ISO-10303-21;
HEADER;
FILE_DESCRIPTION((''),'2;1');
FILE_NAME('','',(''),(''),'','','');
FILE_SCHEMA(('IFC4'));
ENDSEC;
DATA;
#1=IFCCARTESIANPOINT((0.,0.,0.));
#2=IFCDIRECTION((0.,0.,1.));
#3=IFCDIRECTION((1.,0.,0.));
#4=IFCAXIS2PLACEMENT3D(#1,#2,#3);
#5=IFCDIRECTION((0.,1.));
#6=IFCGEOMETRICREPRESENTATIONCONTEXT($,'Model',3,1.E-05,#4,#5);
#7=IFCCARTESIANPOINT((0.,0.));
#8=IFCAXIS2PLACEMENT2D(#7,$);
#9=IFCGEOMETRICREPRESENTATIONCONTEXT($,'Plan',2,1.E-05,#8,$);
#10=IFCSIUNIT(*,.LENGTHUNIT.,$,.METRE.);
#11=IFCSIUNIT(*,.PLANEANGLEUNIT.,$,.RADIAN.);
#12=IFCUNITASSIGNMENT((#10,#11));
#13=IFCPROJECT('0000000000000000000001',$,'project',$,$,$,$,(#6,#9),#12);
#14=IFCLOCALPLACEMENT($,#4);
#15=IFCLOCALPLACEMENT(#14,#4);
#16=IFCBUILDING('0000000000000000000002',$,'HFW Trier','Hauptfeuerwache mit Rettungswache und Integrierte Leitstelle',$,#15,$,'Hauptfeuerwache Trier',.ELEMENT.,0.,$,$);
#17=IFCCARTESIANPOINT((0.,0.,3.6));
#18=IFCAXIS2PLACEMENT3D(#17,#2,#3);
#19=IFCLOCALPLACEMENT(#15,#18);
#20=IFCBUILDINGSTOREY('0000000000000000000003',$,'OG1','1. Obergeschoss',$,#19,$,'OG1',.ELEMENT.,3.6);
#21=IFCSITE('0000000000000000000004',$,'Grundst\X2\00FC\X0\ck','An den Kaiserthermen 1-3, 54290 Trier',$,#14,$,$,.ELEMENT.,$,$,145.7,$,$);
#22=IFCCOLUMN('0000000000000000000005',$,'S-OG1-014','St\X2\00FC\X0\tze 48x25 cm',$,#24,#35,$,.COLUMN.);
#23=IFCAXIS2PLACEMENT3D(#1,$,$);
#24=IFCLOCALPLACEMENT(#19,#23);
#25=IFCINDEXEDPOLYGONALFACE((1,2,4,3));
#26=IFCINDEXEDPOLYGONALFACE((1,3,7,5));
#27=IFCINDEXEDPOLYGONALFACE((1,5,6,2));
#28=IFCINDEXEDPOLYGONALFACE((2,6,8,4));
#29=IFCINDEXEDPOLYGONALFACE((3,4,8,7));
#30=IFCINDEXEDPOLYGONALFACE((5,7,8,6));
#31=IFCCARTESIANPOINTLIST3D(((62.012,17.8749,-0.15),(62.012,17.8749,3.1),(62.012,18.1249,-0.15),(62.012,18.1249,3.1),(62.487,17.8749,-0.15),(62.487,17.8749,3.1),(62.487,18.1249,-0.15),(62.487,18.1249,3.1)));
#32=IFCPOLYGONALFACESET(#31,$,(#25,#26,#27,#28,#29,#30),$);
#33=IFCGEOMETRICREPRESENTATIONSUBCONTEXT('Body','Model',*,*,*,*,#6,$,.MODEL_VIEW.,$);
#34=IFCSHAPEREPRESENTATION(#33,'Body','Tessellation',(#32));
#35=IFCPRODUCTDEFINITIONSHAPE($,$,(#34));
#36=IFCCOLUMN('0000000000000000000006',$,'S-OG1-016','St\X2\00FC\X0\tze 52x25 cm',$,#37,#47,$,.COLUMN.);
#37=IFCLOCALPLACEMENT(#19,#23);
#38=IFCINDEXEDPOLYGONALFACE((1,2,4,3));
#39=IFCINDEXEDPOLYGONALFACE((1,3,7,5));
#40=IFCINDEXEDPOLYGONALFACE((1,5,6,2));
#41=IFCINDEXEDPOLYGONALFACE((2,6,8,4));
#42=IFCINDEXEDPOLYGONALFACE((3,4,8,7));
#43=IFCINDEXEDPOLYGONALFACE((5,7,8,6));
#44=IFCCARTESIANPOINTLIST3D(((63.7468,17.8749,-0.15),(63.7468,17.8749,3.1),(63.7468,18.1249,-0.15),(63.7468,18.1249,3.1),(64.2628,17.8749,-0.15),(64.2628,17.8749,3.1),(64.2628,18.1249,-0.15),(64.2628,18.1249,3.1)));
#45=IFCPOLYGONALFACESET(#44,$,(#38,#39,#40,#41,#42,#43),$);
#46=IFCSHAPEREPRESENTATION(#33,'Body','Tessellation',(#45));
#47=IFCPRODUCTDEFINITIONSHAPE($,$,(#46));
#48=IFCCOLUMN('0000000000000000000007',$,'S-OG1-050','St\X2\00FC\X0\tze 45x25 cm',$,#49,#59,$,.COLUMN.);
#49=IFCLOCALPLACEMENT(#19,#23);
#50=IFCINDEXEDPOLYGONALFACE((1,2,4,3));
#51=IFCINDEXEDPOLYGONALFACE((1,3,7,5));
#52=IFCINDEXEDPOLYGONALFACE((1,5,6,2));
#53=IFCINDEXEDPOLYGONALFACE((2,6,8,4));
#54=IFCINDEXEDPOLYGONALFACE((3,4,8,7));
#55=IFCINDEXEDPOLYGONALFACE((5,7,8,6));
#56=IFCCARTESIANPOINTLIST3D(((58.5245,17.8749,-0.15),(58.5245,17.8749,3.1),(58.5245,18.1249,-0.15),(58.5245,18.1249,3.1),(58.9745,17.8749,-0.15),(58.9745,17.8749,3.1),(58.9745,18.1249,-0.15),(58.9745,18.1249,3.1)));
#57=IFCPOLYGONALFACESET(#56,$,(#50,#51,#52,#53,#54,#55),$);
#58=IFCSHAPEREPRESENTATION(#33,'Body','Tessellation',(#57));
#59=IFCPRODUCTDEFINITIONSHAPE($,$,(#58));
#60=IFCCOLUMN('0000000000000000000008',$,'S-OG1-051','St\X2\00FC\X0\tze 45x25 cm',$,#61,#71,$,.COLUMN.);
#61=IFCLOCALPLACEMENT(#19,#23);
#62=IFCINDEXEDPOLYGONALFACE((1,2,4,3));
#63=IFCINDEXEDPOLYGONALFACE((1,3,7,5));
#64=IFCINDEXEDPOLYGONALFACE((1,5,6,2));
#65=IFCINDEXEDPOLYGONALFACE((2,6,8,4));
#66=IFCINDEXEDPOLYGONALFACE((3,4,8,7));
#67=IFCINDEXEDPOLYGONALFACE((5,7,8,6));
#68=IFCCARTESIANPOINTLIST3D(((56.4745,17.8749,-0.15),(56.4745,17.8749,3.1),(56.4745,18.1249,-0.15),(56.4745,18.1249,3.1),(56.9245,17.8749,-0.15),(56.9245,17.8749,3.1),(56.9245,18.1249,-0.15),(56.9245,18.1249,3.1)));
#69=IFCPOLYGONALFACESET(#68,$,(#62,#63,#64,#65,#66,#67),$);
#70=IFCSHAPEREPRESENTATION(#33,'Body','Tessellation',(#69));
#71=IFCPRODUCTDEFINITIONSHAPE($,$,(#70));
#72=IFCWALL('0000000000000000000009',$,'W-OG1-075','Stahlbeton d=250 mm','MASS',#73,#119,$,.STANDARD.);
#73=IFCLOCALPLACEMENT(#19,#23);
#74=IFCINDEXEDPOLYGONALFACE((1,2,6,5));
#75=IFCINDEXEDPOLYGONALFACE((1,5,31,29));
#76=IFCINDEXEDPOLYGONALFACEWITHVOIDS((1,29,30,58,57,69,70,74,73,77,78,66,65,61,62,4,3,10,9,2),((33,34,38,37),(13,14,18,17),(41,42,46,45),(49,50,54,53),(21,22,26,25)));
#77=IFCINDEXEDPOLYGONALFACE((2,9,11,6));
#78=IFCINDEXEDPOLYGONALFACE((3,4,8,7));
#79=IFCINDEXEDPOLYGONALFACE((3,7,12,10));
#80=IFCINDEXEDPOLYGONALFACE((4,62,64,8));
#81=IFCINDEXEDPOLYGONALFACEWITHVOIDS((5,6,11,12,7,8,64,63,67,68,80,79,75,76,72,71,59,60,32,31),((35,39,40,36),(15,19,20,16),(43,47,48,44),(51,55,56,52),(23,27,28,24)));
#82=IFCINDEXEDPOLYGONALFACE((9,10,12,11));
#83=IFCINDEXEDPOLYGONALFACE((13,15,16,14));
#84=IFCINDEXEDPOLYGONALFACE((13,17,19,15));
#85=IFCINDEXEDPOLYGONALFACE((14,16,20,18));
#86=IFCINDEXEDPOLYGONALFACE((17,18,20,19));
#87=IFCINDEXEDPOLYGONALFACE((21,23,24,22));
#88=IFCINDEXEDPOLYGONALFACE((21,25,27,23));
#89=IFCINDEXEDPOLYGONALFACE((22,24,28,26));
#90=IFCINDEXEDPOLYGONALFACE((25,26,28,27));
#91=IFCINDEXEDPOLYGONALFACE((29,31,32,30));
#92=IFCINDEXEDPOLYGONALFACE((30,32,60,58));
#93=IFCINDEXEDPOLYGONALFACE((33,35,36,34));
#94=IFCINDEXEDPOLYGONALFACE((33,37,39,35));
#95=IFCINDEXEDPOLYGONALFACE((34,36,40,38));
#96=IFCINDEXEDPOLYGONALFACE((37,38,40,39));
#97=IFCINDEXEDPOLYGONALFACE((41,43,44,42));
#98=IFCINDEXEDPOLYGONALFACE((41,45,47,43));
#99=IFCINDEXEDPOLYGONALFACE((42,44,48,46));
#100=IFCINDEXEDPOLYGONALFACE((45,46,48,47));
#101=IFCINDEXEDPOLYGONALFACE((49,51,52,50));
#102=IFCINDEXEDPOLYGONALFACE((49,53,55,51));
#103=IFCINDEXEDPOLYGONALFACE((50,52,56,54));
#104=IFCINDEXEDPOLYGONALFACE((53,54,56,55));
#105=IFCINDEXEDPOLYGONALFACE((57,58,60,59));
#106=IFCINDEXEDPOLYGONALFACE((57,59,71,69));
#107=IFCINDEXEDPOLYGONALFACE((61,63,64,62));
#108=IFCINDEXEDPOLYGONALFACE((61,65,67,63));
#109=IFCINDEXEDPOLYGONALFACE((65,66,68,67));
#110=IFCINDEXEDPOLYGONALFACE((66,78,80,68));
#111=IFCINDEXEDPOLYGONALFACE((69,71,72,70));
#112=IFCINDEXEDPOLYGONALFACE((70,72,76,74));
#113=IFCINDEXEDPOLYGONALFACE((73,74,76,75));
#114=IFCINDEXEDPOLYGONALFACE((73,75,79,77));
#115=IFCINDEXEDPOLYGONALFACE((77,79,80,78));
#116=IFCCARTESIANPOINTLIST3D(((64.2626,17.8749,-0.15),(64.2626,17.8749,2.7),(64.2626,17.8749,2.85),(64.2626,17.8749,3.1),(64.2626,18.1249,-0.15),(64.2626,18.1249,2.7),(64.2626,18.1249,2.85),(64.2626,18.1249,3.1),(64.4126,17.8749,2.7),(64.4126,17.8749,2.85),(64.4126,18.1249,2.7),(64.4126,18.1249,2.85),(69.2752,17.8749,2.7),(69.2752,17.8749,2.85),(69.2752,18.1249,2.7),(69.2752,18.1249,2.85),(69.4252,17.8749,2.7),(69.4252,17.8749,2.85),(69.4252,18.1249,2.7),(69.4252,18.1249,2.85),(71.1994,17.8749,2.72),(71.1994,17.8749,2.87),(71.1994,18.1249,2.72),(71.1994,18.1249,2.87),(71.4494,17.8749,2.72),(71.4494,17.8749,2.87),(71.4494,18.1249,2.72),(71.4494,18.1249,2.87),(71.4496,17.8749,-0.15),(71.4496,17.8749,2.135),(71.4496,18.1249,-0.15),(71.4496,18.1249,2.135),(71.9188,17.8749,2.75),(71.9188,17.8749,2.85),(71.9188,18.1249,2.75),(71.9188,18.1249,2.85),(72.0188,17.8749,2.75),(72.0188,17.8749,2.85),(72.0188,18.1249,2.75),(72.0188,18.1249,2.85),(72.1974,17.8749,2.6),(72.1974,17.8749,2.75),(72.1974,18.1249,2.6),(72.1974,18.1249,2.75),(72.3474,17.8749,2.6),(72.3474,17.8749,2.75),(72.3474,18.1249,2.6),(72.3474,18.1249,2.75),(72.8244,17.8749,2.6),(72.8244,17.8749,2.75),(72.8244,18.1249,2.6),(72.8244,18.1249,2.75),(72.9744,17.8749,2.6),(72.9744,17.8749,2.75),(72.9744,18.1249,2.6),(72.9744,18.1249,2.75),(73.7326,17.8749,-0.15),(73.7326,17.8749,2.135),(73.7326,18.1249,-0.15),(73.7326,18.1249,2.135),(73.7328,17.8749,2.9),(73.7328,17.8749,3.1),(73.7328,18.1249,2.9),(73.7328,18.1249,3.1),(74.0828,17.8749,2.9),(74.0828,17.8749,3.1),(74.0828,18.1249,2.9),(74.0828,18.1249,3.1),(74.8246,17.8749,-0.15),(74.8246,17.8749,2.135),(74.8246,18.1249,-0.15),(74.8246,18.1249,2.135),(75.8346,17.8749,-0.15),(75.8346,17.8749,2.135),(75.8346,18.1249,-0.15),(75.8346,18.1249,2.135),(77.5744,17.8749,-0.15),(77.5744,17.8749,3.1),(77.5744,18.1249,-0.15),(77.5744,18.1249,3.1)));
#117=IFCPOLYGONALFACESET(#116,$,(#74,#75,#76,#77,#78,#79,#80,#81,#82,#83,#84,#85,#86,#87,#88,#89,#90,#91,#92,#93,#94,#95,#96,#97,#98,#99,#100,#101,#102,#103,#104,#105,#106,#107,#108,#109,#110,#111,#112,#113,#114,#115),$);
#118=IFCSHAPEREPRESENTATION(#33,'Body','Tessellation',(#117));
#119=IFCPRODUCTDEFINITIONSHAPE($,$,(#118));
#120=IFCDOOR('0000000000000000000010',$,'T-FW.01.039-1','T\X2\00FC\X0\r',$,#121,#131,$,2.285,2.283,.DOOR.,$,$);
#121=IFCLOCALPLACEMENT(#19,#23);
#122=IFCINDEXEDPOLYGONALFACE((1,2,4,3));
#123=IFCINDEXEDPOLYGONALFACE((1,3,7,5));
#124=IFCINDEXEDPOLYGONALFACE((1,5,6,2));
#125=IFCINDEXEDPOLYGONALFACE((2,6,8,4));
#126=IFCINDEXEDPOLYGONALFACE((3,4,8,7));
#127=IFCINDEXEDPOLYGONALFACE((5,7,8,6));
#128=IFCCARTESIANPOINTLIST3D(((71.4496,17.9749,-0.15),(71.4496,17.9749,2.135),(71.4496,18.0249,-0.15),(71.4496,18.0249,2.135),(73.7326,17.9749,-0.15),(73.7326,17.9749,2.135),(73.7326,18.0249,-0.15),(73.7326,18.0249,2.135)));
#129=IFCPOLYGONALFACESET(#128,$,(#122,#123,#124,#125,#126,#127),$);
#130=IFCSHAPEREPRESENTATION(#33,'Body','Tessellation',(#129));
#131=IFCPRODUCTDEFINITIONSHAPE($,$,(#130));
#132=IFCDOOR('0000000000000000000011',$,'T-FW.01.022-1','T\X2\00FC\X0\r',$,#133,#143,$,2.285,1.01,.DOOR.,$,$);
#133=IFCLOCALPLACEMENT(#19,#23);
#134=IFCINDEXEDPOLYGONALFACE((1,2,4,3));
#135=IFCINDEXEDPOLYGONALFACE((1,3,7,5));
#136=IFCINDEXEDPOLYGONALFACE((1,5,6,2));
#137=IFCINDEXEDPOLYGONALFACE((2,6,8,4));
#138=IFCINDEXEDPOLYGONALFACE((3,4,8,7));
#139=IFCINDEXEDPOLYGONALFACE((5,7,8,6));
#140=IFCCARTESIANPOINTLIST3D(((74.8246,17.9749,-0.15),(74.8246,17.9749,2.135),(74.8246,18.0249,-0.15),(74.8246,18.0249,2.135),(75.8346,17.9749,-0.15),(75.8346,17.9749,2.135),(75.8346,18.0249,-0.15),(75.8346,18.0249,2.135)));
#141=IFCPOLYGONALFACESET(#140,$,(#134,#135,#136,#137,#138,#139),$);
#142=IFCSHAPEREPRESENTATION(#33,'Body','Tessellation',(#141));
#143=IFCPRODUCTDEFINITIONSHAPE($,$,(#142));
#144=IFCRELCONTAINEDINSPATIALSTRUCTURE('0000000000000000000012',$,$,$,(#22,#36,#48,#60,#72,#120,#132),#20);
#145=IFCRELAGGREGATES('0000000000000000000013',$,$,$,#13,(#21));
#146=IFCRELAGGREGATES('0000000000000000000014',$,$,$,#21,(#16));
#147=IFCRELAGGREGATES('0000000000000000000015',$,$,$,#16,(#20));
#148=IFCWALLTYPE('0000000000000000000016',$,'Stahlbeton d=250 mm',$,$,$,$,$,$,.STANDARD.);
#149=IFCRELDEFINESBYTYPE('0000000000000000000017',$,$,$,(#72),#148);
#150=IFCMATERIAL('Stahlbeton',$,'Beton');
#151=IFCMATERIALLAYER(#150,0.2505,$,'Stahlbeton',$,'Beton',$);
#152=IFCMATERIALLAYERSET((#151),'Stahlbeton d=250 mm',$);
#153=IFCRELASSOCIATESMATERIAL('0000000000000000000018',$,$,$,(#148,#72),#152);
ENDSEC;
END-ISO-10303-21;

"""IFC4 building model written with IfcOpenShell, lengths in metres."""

from ifc_helpers import new_model, si_unit, direction, frame, frame_2d, origin_with_axes, origin_2d, place, context, subcontext, project, spatial, rectangle, extrude, material, layer, layer_set, layer_usage, type_object, element, fill, save


model = new_model("IFC4")

# Units and contexts
model_context = context("Model", 3, precision=1e-05, world=origin_with_axes(), true_north=direction((0.0, 1.0)))
plan_context = context("Plan", 2, precision=1e-05, world=origin_2d())
body_context = subcontext(model_context, "Body", "Model", "MODEL_VIEW")
ifc_project = project(units=[si_unit("LENGTHUNIT", "METRE"), si_unit("PLANEANGLEUNIT", "RADIAN")], contexts=[model_context, plan_context])

# Site, building, storey
site_placement = place(None, origin_with_axes())
site = spatial("IfcSite", under=ifc_project, at=site_placement, Name="Grundstück", Description="An den Kaiserthermen 1-3, 54290 Trier", CompositionType="ELEMENT", RefElevation=145.7)
building_placement = place(site_placement, origin_with_axes())
building = spatial("IfcBuilding", under=site, at=building_placement, Name="HFW Trier", Description="Hauptfeuerwache mit Rettungswache und Integrierte Leitstelle", LongName="Hauptfeuerwache Trier", CompositionType="ELEMENT", ElevationOfRefHeight=0.0)
storey_placement = place(building_placement, frame((0.0, 0.0, 3.6), z_axis=(0.0, 0.0, 1.0), x_axis=(1.0, 0.0, 0.0)))
storey = spatial("IfcBuildingStorey", under=building, at=storey_placement, Name="OG1", Description="1. Obergeschoss", LongName="OG1", CompositionType="ELEMENT", Elevation=3.6)

# Columns
column_1_placement = place(storey_placement, frame((62.012, 17.9999, -0.15), z_axis=(0.0, 0.0, 1.0), x_axis=(1.0, 0.0, 0.0)))
element("IfcColumn", 1, at=column_1_placement, inside=storey, Name="S-OG1-014", Description="Stütze 48x25 cm", PredefinedType="COLUMN", context=body_context, shape_type="SweptSolid", body=[
    extrude(rectangle(XDim=0.475, YDim=0.25, at=frame_2d((0.2375, 0.0))), origin_with_axes(), (0.0, 0.0, 1.0), 3.25),
])
column_2_placement = place(storey_placement, frame((63.7468, 17.9999, -0.15), z_axis=(0.0, 0.0, 1.0), x_axis=(1.0, 0.0, 0.0)))
element("IfcColumn", 2, at=column_2_placement, inside=storey, Name="S-OG1-016", Description="Stütze 52x25 cm", PredefinedType="COLUMN", context=body_context, shape_type="SweptSolid", body=[
    extrude(rectangle(XDim=0.516, YDim=0.25, at=frame_2d((0.258, 0.0))), origin_with_axes(), (0.0, 0.0, 1.0), 3.25),
])
for number, where, z_axis, x_axis, name in (
    (3, (58.5245, 17.9999, -0.15), (0.0, 0.0, 1.0), (1.0, 0.0, 0.0), "S-OG1-050"),
    (4, (56.4745, 17.9999, -0.15), (0.0, 0.0, 1.0), (1.0, 0.0, 0.0), "S-OG1-051"),
):
    element("IfcColumn", number, at=place(storey_placement, frame(where, z_axis=z_axis, x_axis=x_axis)), inside=storey, Name=name, Description="Stütze 45x25 cm", PredefinedType="COLUMN", context=body_context, shape_type="SweptSolid", body=[
        extrude(rectangle(XDim=0.45, YDim=0.25, at=frame_2d((0.225, 0.0))), origin_with_axes(), (0.0, 0.0, 1.0), 3.25),
    ])

# Wall, openings, doors
ifc_material = material(Name="Stahlbeton", Category="Beton")
ifc_layer_1 = layer(ifc_material, 0.2505, Name="Stahlbeton", Category="Beton")
ifc_layer_set_1 = layer_set([ifc_layer_1], Name="Stahlbeton d=250 mm")
ifc_layer_usage_1 = layer_usage(ifc_layer_set_1, "AXIS2", "POSITIVE", -0.125)
wall_type_1 = type_object("IfcWallType", Name="Stahlbeton d=250 mm", PredefinedType="STANDARD", material=ifc_layer_set_1)
wall_1_placement = place(storey_placement, frame((64.2626, 17.9999, -0.15), z_axis=(0.0, 0.0, 1.0), x_axis=(1.0, 0.0, 0.0)))
wall_1 = element("IfcWall", 5, at=wall_1_placement, inside=storey, type_object=wall_type_1, material=ifc_layer_usage_1, Name="W-OG1-075", Description="Stahlbeton d=250 mm", ObjectType="MASS", PredefinedType="STANDARD", context=body_context, shape_type="SweptSolid", body=[
    extrude(rectangle(XDim=13.3118, YDim=0.25, at=frame_2d((6.6559, 0.0))), origin_with_axes(), (0.0, 0.0, 1.0), 3.25),
])
opening_1_placement = place(wall_1_placement, frame((7.187, 0.0, 0.0), z_axis=(0.0, 0.0, 1.0), x_axis=(1.0, 0.0, 0.0)))
opening_1 = element("IfcOpeningElement", 6, at=opening_1_placement, cuts=wall_1, PredefinedType="OPENING", context=body_context, shape_type="SweptSolid", body=[
    extrude(rectangle(XDim=2.283, YDim=0.35, at=frame_2d((1.1415, 0.0))), origin_with_axes(), (0.0, 0.0, 1.0), 2.285),
])
opening_2_placement = place(wall_1_placement, frame((10.562, 0.0, 0.0), z_axis=(0.0, 0.0, 1.0), x_axis=(1.0, 0.0, 0.0)))
opening_2 = element("IfcOpeningElement", 7, at=opening_2_placement, cuts=wall_1, PredefinedType="OPENING", context=body_context, shape_type="SweptSolid", body=[
    extrude(rectangle(XDim=1.01, YDim=0.35, at=frame_2d((0.505, 0.0))), origin_with_axes(), (0.0, 0.0, 1.0), 2.285),
])
opening_3_placement = place(wall_1_placement, origin_with_axes())
element("IfcOpeningElement", 8, at=opening_3_placement, cuts=wall_1, ObjectType="Wanddurchbruch", PredefinedType="OPENING", context=body_context, shape_type="SweptSolid", body=[
    extrude(rectangle(XDim=0.15, YDim=0.35, at=frame_2d((0.075, 0.0))), frame((0.0, 0.0, 2.85), z_axis=(0.0, 0.0, 1.0), x_axis=(1.0, 0.0, 0.0)), (0.0, 0.0, 1.0), 0.15),
])
opening_4_placement = place(wall_1_placement, origin_with_axes())
element("IfcOpeningElement", 9, at=opening_4_placement, cuts=wall_1, ObjectType="Wanddurchbruch", PredefinedType="OPENING", context=body_context, shape_type="SweptSolid", body=[
    extrude(rectangle(XDim=0.15, YDim=0.35, at=frame_2d((5.0876, 0.0))), frame((0.0, 0.0, 2.85), z_axis=(0.0, 0.0, 1.0), x_axis=(1.0, 0.0, 0.0)), (0.0, 0.0, 1.0), 0.15),
])
opening_5_placement = place(wall_1_placement, origin_with_axes())
element("IfcOpeningElement", 10, at=opening_5_placement, cuts=wall_1, ObjectType="Wanddurchbruch", PredefinedType="OPENING", context=body_context, shape_type="SweptSolid", body=[
    extrude(rectangle(XDim=0.15, YDim=0.35, at=frame_2d((8.0098, 0.0))), frame((0.0, 0.0, 2.75), z_axis=(0.0, 0.0, 1.0), x_axis=(1.0, 0.0, 0.0)), (0.0, 0.0, 1.0), 0.15),
])
opening_6_placement = place(wall_1_placement, origin_with_axes())
element("IfcOpeningElement", 11, at=opening_6_placement, cuts=wall_1, ObjectType="Wanddurchbruch", PredefinedType="OPENING", context=body_context, shape_type="SweptSolid", body=[
    extrude(rectangle(XDim=0.25, YDim=0.35, at=frame_2d((7.0618, 0.0))), frame((0.0, 0.0, 2.87), z_axis=(0.0, 0.0, 1.0), x_axis=(1.0, 0.0, 0.0)), (0.0, 0.0, 1.0), 0.15),
])
opening_7_placement = place(wall_1_placement, origin_with_axes())
element("IfcOpeningElement", 12, at=opening_7_placement, cuts=wall_1, ObjectType="Wanddurchbruch", PredefinedType="OPENING", context=body_context, shape_type="SweptSolid", body=[
    extrude(rectangle(XDim=0.1, YDim=0.35, at=frame_2d((7.7062, 0.0))), frame((0.0, 0.0, 2.9), z_axis=(0.0, 0.0, 1.0), x_axis=(1.0, 0.0, 0.0)), (0.0, 0.0, 1.0), 0.1),
])
opening_8_placement = place(wall_1_placement, origin_with_axes())
element("IfcOpeningElement", 13, at=opening_8_placement, cuts=wall_1, ObjectType="Wanddurchbruch", PredefinedType="OPENING", context=body_context, shape_type="SweptSolid", body=[
    extrude(rectangle(XDim=0.35, YDim=0.35, at=frame_2d((9.6452, 0.0))), frame((0.0, 0.0, 3.05), z_axis=(0.0, 0.0, 1.0), x_axis=(1.0, 0.0, 0.0)), (0.0, 0.0, 1.0), 0.2),
])
opening_9_placement = place(wall_1_placement, origin_with_axes())
element("IfcOpeningElement", 14, at=opening_9_placement, cuts=wall_1, ObjectType="Wanddurchbruch", PredefinedType="OPENING", context=body_context, shape_type="SweptSolid", body=[
    extrude(rectangle(XDim=0.15, YDim=0.35, at=frame_2d((8.6368, 0.0))), frame((0.0, 0.0, 2.75), z_axis=(0.0, 0.0, 1.0), x_axis=(1.0, 0.0, 0.0)), (0.0, 0.0, 1.0), 0.15),
])
door_1_placement = place(wall_1_placement, frame((7.187, 0.0, 0.0), z_axis=(0.0, 0.0, 1.0), x_axis=(1.0, 0.0, 0.0)))
door_1 = element("IfcDoor", 15, at=door_1_placement, inside=storey, Name="T-FW.01.039-1", Description="Tür", OverallHeight=2.285, OverallWidth=2.283, PredefinedType="DOOR", context=body_context, shape_type="SweptSolid", body=[
    extrude(rectangle(XDim=2.283, YDim=0.05, at=frame_2d((1.1415, 0.0))), origin_with_axes(), (0.0, 0.0, 1.0), 2.285),
])
fill(opening_1, door_1)
door_2_placement = place(wall_1_placement, frame((10.562, 0.0, 0.0), z_axis=(0.0, 0.0, 1.0), x_axis=(1.0, 0.0, 0.0)))
door_2 = element("IfcDoor", 16, at=door_2_placement, inside=storey, Name="T-FW.01.022-1", Description="Tür", OverallHeight=2.285, OverallWidth=1.01, PredefinedType="DOOR", context=body_context, shape_type="SweptSolid", body=[
    extrude(rectangle(XDim=1.01, YDim=0.05, at=frame_2d((0.505, 0.0))), origin_with_axes(), (0.0, 0.0, 1.0), 2.285),
])
fill(opening_2, door_2)

save(model, "model.ifc")
